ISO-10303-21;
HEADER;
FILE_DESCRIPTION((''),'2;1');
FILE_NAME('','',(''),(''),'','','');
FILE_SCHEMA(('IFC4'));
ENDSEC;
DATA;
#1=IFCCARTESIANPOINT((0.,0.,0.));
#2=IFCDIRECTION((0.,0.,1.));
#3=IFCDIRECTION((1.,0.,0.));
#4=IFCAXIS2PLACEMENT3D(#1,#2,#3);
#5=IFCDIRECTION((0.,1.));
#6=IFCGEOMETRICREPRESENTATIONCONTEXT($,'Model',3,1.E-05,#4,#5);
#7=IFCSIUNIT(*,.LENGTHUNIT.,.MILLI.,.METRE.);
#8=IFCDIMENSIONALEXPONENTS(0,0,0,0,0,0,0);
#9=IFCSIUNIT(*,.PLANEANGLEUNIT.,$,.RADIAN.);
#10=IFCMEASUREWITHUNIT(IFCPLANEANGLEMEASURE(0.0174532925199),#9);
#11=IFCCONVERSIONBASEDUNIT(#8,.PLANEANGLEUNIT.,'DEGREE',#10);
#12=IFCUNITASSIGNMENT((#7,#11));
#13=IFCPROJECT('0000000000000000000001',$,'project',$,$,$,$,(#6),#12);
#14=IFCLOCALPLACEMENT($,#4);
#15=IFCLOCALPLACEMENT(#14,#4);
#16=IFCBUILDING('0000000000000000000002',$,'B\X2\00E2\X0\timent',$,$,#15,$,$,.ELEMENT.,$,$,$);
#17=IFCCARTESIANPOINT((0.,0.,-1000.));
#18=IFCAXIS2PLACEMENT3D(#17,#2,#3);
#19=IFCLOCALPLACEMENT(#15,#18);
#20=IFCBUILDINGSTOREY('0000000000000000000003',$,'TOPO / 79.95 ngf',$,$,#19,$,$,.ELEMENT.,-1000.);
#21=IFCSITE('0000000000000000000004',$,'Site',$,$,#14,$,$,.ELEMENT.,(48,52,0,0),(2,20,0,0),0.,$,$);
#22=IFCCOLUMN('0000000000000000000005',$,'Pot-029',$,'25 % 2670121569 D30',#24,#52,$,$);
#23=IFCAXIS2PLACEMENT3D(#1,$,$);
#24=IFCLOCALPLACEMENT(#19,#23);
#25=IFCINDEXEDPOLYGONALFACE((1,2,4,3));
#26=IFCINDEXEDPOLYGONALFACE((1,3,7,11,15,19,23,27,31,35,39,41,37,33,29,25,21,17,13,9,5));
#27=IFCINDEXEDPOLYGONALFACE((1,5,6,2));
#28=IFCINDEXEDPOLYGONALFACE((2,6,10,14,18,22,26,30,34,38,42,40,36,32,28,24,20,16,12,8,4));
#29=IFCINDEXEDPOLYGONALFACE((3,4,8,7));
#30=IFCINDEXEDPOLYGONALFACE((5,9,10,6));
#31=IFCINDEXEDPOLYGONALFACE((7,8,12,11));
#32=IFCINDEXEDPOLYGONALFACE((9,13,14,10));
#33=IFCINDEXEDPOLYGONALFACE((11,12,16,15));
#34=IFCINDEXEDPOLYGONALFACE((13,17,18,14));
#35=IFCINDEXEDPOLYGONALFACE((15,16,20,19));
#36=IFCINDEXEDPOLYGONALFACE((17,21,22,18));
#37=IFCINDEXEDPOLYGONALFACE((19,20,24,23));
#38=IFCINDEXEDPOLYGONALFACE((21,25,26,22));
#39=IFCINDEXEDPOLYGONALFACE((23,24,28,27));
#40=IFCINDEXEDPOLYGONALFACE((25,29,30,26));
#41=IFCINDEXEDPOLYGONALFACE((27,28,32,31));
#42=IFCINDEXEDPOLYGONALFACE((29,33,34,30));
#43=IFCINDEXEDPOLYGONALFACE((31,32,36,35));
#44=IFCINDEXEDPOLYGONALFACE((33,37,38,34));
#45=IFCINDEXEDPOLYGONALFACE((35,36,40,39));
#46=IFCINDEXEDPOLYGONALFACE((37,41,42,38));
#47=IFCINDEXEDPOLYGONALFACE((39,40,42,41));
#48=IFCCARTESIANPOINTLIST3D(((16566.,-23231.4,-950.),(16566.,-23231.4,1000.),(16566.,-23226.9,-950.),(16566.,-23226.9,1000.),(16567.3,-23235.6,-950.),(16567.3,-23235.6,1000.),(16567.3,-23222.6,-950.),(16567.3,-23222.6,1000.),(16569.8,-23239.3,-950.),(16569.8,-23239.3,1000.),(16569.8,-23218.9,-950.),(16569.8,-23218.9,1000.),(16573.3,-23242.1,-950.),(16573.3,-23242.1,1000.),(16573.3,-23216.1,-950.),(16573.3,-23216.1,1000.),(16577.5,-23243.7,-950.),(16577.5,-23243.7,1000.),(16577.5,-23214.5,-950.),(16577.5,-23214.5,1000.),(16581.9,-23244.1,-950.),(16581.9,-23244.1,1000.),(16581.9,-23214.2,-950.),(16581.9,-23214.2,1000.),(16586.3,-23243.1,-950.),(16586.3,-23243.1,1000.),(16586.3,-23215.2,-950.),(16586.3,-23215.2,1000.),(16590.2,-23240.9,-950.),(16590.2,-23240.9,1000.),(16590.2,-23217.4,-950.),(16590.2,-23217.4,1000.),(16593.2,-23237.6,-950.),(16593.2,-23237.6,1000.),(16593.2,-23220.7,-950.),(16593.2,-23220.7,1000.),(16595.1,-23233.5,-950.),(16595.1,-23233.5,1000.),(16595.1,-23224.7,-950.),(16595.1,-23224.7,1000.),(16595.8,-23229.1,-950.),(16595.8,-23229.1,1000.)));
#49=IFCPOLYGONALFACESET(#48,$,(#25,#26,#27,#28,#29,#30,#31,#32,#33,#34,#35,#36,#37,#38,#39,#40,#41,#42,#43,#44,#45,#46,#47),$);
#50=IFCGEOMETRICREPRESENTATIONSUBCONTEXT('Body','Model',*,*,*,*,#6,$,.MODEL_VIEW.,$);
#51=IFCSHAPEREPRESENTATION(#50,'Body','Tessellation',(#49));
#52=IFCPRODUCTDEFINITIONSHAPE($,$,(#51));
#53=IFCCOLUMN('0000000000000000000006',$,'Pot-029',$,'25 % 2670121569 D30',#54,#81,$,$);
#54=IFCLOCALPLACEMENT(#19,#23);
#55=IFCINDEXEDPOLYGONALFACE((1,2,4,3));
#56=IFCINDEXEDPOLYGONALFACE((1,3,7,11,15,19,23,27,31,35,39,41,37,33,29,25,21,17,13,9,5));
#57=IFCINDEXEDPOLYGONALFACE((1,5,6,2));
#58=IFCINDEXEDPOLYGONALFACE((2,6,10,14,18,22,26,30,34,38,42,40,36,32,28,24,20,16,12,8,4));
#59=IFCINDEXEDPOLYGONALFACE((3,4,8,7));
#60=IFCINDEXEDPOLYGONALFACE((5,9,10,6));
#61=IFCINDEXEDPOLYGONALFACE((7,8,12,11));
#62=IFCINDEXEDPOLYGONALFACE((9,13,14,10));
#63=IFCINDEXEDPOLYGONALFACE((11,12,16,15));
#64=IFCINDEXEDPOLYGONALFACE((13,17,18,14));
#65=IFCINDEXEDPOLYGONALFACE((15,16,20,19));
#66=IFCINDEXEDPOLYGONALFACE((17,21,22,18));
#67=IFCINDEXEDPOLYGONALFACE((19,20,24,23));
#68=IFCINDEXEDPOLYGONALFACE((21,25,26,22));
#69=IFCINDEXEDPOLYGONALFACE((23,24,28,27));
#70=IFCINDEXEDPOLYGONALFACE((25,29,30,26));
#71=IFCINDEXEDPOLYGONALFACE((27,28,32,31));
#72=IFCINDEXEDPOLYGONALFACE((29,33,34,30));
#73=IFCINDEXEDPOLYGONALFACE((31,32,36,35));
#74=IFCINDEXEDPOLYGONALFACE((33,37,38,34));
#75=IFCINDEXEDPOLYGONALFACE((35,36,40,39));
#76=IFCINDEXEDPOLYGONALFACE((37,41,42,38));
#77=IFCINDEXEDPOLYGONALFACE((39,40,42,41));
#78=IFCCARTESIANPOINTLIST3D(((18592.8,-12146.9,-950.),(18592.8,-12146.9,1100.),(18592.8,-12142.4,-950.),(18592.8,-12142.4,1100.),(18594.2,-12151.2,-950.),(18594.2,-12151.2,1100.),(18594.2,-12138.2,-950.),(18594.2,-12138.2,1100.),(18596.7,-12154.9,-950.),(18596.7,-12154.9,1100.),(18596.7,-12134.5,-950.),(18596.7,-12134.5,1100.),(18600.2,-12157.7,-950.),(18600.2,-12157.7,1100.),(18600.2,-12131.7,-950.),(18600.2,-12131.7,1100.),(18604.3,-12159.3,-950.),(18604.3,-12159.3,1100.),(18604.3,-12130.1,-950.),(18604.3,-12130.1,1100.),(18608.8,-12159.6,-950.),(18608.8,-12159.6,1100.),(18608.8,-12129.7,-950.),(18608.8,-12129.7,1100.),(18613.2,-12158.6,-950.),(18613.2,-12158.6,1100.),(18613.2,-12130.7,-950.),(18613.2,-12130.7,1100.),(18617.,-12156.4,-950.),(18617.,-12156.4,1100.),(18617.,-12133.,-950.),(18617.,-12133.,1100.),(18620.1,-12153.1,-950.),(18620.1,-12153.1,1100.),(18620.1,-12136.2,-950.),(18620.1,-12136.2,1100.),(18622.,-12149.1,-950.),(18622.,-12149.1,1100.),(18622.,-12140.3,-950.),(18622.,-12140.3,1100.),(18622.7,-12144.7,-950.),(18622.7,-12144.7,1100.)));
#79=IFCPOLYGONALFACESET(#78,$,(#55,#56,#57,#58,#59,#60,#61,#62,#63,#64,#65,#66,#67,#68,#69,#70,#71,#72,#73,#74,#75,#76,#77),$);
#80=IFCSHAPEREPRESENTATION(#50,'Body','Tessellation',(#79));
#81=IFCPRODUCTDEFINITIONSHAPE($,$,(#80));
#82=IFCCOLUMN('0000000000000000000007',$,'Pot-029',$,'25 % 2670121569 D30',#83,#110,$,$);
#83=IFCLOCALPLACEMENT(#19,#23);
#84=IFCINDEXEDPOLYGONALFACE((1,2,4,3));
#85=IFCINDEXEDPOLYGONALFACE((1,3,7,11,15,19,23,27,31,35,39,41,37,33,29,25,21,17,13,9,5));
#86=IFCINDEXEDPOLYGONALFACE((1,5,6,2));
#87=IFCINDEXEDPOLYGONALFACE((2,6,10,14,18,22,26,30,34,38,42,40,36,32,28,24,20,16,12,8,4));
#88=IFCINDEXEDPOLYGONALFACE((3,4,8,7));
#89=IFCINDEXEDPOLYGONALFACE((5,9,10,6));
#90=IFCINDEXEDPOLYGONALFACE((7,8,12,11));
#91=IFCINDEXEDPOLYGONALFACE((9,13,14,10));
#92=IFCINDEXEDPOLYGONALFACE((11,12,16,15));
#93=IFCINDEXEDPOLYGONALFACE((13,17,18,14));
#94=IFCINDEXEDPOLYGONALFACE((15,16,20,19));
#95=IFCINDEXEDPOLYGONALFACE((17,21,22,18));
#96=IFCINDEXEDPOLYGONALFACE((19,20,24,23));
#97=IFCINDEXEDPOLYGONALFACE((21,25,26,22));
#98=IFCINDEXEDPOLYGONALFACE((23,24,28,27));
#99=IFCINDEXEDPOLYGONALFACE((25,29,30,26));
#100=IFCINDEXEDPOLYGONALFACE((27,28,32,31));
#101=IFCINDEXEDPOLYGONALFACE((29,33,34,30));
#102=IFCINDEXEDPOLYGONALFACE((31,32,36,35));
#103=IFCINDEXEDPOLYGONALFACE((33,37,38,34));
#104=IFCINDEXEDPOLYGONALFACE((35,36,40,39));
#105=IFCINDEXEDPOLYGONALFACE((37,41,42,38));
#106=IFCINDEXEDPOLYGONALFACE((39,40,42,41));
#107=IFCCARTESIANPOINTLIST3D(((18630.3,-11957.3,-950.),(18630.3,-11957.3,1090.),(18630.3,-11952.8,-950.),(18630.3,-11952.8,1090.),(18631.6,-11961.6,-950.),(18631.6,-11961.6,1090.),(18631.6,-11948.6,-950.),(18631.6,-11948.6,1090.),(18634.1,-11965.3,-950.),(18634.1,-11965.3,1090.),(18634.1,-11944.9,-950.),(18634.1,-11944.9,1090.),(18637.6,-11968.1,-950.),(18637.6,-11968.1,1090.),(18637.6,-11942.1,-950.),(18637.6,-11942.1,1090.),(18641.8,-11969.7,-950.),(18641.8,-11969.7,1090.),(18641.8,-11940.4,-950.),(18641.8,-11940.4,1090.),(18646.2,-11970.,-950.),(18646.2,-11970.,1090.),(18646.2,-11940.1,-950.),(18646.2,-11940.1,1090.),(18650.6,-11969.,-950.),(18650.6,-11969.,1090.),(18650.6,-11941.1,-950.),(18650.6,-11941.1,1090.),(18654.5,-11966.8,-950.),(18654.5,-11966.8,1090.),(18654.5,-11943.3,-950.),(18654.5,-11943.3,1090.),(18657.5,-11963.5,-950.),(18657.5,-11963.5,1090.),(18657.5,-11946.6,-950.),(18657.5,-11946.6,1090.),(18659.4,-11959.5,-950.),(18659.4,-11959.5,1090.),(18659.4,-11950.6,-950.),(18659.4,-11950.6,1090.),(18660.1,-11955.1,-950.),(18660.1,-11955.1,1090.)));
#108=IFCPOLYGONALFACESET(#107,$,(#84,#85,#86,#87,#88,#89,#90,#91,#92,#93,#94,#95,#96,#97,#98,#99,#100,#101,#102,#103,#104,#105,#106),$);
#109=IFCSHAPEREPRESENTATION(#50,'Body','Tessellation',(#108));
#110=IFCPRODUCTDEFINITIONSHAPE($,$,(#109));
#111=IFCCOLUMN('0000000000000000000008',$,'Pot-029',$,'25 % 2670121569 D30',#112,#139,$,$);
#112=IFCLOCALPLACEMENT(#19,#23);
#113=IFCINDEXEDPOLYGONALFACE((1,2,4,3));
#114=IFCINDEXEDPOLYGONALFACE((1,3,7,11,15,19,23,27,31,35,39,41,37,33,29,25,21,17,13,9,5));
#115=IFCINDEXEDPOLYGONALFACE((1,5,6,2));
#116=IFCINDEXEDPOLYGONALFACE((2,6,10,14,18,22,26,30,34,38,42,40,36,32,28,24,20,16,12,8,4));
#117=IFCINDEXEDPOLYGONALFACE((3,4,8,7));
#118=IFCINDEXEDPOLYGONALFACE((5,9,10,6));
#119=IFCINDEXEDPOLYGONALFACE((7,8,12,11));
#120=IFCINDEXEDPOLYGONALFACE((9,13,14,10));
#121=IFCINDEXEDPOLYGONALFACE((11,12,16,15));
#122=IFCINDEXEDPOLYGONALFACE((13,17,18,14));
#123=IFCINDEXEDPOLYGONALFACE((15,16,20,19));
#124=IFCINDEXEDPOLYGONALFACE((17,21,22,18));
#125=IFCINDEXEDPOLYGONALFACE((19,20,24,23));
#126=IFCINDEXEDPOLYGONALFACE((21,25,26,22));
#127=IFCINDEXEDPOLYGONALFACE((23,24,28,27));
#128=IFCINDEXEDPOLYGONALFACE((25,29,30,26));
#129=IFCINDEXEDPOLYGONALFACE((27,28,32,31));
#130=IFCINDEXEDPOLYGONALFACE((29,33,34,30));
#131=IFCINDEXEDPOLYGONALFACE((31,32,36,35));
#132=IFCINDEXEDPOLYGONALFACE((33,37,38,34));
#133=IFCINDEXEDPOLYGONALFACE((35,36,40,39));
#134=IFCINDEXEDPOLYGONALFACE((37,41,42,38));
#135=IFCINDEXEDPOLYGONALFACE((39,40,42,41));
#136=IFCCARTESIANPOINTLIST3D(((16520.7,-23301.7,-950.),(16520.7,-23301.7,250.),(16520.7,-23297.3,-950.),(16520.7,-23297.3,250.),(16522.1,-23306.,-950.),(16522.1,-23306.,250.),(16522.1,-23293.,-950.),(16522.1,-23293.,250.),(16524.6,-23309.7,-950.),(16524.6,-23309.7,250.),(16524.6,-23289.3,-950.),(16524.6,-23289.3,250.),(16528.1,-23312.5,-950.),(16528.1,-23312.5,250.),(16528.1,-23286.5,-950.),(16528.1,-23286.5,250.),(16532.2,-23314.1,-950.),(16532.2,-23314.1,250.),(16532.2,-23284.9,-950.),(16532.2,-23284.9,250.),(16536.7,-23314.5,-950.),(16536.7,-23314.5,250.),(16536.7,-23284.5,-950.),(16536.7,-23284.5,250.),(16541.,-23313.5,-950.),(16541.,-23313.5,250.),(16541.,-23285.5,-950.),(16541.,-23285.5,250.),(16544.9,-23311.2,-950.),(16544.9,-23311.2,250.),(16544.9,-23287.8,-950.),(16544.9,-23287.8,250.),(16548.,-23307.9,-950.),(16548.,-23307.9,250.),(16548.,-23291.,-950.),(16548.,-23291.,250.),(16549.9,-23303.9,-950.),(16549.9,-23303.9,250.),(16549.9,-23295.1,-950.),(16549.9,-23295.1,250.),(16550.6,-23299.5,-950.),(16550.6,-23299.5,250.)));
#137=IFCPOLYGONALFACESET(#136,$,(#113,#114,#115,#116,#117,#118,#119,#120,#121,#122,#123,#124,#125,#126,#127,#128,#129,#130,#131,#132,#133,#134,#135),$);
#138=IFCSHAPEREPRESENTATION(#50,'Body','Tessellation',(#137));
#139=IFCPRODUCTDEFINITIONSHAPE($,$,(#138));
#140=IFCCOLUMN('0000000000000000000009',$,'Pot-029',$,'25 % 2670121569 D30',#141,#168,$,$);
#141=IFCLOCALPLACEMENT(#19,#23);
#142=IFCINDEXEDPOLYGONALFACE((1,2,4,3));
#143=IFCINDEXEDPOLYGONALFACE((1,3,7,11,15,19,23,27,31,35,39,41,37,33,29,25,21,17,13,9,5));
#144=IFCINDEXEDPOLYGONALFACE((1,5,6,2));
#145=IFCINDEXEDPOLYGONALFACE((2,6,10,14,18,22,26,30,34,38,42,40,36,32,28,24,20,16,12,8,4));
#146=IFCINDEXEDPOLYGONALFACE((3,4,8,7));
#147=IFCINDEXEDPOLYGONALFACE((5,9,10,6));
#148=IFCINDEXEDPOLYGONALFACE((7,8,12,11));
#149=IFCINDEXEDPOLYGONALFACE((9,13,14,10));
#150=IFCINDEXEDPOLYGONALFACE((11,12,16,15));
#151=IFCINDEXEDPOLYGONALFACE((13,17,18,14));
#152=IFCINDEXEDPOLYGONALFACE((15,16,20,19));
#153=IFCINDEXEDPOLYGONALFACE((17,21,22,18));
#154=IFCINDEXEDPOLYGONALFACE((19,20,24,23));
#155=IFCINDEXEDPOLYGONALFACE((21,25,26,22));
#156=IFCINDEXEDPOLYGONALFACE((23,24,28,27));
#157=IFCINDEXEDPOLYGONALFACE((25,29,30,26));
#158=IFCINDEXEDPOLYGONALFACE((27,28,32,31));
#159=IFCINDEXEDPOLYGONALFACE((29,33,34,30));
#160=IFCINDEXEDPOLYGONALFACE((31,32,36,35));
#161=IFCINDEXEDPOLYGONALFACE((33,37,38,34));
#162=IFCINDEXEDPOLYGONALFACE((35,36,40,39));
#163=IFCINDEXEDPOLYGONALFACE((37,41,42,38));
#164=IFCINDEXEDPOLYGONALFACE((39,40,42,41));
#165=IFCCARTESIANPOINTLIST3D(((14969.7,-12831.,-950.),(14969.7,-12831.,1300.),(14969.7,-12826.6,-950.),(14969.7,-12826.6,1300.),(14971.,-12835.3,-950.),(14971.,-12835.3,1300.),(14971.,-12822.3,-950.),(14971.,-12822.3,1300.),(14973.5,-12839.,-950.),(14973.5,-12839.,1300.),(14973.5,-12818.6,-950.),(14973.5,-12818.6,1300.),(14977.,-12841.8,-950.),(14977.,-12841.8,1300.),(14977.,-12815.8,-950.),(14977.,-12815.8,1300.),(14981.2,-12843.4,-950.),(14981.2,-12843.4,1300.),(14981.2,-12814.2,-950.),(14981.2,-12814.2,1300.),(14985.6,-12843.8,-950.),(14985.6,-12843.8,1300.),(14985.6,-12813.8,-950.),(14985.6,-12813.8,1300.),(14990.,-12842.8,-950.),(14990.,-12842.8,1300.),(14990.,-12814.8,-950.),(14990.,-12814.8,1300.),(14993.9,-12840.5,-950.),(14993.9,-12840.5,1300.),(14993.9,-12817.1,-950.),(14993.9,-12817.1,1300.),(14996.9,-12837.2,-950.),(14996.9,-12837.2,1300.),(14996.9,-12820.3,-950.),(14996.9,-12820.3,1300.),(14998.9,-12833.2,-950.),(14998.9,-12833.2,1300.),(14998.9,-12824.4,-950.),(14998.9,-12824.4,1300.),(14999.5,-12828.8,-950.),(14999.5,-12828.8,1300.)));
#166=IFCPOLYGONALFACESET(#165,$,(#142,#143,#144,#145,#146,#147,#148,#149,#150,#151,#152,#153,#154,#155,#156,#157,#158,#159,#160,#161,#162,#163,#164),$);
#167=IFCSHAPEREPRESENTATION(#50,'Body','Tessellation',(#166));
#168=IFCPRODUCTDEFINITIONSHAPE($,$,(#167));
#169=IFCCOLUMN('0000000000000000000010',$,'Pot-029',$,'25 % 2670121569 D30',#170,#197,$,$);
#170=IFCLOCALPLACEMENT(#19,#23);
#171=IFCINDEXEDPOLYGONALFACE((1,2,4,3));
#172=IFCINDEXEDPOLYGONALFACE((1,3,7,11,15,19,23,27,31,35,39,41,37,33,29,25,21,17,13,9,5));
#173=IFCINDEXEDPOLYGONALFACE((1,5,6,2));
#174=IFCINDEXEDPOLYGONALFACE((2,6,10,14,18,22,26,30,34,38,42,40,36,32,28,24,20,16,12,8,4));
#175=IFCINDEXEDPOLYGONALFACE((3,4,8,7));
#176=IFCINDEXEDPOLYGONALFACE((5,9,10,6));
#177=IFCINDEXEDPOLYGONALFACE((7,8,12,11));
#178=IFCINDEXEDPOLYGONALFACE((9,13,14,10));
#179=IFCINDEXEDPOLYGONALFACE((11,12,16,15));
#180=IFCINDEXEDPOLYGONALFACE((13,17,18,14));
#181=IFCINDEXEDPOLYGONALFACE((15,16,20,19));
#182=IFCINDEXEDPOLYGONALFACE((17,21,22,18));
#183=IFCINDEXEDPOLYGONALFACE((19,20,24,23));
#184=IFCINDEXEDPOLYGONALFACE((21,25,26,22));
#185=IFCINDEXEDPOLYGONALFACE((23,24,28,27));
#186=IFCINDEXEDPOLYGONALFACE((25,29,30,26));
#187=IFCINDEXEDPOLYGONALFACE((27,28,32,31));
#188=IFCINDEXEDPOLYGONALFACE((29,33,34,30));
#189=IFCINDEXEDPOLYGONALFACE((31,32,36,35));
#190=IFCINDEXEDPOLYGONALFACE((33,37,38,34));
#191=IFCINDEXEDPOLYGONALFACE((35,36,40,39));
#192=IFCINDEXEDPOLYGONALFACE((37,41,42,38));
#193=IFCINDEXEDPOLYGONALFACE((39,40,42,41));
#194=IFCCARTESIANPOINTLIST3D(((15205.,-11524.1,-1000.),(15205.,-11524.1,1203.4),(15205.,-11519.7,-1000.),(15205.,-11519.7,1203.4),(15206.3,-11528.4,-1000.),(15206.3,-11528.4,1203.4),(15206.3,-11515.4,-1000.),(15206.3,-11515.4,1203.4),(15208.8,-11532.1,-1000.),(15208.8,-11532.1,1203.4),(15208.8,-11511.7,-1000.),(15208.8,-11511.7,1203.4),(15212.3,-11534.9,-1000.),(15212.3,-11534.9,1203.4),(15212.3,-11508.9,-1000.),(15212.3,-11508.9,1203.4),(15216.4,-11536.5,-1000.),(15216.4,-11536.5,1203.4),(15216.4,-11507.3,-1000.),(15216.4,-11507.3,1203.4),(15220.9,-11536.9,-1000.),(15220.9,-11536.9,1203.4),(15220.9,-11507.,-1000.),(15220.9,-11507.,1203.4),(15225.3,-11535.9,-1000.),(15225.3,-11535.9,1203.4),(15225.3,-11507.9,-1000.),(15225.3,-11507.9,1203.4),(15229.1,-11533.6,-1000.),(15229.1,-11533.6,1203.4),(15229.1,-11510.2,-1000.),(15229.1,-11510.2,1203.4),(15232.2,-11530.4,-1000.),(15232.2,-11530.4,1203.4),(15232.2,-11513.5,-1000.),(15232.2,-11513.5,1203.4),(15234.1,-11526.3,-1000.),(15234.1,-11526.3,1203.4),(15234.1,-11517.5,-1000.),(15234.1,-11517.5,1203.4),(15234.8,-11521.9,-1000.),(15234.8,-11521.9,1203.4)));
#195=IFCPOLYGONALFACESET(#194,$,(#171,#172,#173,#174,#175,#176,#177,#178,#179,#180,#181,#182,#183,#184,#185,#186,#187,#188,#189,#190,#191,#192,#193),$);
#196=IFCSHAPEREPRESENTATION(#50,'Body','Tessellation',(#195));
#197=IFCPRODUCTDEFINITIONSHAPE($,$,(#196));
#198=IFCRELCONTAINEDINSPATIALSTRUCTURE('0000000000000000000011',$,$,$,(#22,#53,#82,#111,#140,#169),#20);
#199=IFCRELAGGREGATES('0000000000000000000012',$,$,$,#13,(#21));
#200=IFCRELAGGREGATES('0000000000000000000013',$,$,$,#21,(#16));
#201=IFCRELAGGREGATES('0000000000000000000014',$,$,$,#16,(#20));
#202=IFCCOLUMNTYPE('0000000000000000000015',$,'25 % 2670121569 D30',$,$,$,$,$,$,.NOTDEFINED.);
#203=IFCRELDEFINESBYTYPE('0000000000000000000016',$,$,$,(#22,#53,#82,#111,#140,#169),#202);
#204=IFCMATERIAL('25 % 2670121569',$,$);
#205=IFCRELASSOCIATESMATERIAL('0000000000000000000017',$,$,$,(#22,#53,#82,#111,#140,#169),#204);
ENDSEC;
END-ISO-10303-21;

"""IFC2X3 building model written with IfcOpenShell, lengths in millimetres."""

from ifc_helpers import new_model, entity, si_unit, converted_unit, direction, frame, origin_with_axes, origin_2d_with_axis, place, context, subcontext, project, spatial, circle, extrude, material, type_object, element, save


model = new_model("IFC2X3")

# Units and contexts
model_context = context("Model", 3, precision=1e-05, world=origin_with_axes(), true_north=direction((0.0, 1.0)))
body_context = subcontext(model_context, "Body", "Model", "MODEL_VIEW")
ifc_project = project(units=[si_unit("LENGTHUNIT", "METRE", prefix="MILLI"), converted_unit("PLANEANGLEUNIT", "DEGREE", entity("IfcPlaneAngleMeasure", 0.0174532925199), si_unit("PLANEANGLEUNIT", "RADIAN"), dimensions=[0, 0, 0, 0, 0, 0, 0])], contexts=[model_context])

# Site, building, storey
site_placement = place(None, origin_with_axes())
site = spatial("IfcSite", under=ifc_project, at=site_placement, Name="Site", CompositionType="ELEMENT", RefLatitude=(48, 52, 0, 0), RefLongitude=(2, 20, 0, 0), RefElevation=0.0)
building_placement = place(site_placement, origin_with_axes())
building = spatial("IfcBuilding", under=site, at=building_placement, Name="Bâtiment", CompositionType="ELEMENT")
storey_placement = place(building_placement, frame((0.0, 0.0, -1000.0), z_axis=(0.0, 0.0, 1.0), x_axis=(1.0, 0.0, 0.0)))
storey = spatial("IfcBuildingStorey", under=building, at=storey_placement, Name="TOPO / 79.95 ngf", CompositionType="ELEMENT", Elevation=-1000.0)

# Columns
ifc_material_1 = material(Name="25 % 2670121569")
column_type = type_object("IfcColumnType", Name="25 % 2670121569 D30", PredefinedType="NOTDEFINED")
column_1_placement = place(storey_placement, frame((16580.8, -23229.1, -950.0), z_axis=(0.0, 0.0, 1.0), x_axis=(1.0, 0.0, 0.0)))
element("IfcColumn", 1, at=column_1_placement, inside=storey, type_object=column_type, material=ifc_material_1, Name="Pot-029", ObjectType="25 % 2670121569 D30", context=body_context, shape_type="SweptSolid", body=[
    extrude(circle(Radius=15.0, at=origin_2d_with_axis()), origin_with_axes(), (0.0, 0.0, 1.0), 1950.0),
])
column_2_placement = place(storey_placement, frame((18607.7, -12144.7, -950.0), z_axis=(0.0, 0.0, 1.0), x_axis=(1.0, 0.0, 0.0)))
element("IfcColumn", 2, at=column_2_placement, inside=storey, type_object=column_type, material=ifc_material_1, Name="Pot-029", ObjectType="25 % 2670121569 D30", context=body_context, shape_type="SweptSolid", body=[
    extrude(circle(Radius=15.0, at=origin_2d_with_axis()), origin_with_axes(), (0.0, 0.0, 1.0), 2050.0),
])
column_3_placement = place(storey_placement, frame((18645.1, -11955.1, -950.0), z_axis=(0.0, 0.0, 1.0), x_axis=(1.0, 0.0, 0.0)))
element("IfcColumn", 3, at=column_3_placement, inside=storey, type_object=column_type, material=ifc_material_1, Name="Pot-029", ObjectType="25 % 2670121569 D30", context=body_context, shape_type="SweptSolid", body=[
    extrude(circle(Radius=15.0, at=origin_2d_with_axis()), origin_with_axes(), (0.0, 0.0, 1.0), 2040.0),
])
column_4_placement = place(storey_placement, frame((16535.6, -23299.5, -950.0), z_axis=(0.0, 0.0, 1.0), x_axis=(1.0, 0.0, 0.0)))
element("IfcColumn", 4, at=column_4_placement, inside=storey, type_object=column_type, material=ifc_material_1, Name="Pot-029", ObjectType="25 % 2670121569 D30", context=body_context, shape_type="SweptSolid", body=[
    extrude(circle(Radius=15.0, at=origin_2d_with_axis()), origin_with_axes(), (0.0, 0.0, 1.0), 1200.0),
])
column_5_placement = place(storey_placement, frame((14984.5, -12828.8, -950.0), z_axis=(0.0, 0.0, 1.0), x_axis=(1.0, 0.0, 0.0)))
element("IfcColumn", 5, at=column_5_placement, inside=storey, type_object=column_type, material=ifc_material_1, Name="Pot-029", ObjectType="25 % 2670121569 D30", context=body_context, shape_type="SweptSolid", body=[
    extrude(circle(Radius=15.0, at=origin_2d_with_axis()), origin_with_axes(), (0.0, 0.0, 1.0), 2250.0),
])
column_6_placement = place(storey_placement, frame((15219.8, -11521.9, -1000.0), z_axis=(0.0, 0.0, 1.0), x_axis=(1.0, 0.0, 0.0)))
element("IfcColumn", 6, at=column_6_placement, inside=storey, type_object=column_type, material=ifc_material_1, Name="Pot-029", ObjectType="25 % 2670121569 D30", context=body_context, shape_type="SweptSolid", body=[
    extrude(circle(Radius=15.0, at=origin_2d_with_axis()), origin_with_axes(), (0.0, 0.0, 1.0), 2203.4),
])

save(model, "model.ifc")
